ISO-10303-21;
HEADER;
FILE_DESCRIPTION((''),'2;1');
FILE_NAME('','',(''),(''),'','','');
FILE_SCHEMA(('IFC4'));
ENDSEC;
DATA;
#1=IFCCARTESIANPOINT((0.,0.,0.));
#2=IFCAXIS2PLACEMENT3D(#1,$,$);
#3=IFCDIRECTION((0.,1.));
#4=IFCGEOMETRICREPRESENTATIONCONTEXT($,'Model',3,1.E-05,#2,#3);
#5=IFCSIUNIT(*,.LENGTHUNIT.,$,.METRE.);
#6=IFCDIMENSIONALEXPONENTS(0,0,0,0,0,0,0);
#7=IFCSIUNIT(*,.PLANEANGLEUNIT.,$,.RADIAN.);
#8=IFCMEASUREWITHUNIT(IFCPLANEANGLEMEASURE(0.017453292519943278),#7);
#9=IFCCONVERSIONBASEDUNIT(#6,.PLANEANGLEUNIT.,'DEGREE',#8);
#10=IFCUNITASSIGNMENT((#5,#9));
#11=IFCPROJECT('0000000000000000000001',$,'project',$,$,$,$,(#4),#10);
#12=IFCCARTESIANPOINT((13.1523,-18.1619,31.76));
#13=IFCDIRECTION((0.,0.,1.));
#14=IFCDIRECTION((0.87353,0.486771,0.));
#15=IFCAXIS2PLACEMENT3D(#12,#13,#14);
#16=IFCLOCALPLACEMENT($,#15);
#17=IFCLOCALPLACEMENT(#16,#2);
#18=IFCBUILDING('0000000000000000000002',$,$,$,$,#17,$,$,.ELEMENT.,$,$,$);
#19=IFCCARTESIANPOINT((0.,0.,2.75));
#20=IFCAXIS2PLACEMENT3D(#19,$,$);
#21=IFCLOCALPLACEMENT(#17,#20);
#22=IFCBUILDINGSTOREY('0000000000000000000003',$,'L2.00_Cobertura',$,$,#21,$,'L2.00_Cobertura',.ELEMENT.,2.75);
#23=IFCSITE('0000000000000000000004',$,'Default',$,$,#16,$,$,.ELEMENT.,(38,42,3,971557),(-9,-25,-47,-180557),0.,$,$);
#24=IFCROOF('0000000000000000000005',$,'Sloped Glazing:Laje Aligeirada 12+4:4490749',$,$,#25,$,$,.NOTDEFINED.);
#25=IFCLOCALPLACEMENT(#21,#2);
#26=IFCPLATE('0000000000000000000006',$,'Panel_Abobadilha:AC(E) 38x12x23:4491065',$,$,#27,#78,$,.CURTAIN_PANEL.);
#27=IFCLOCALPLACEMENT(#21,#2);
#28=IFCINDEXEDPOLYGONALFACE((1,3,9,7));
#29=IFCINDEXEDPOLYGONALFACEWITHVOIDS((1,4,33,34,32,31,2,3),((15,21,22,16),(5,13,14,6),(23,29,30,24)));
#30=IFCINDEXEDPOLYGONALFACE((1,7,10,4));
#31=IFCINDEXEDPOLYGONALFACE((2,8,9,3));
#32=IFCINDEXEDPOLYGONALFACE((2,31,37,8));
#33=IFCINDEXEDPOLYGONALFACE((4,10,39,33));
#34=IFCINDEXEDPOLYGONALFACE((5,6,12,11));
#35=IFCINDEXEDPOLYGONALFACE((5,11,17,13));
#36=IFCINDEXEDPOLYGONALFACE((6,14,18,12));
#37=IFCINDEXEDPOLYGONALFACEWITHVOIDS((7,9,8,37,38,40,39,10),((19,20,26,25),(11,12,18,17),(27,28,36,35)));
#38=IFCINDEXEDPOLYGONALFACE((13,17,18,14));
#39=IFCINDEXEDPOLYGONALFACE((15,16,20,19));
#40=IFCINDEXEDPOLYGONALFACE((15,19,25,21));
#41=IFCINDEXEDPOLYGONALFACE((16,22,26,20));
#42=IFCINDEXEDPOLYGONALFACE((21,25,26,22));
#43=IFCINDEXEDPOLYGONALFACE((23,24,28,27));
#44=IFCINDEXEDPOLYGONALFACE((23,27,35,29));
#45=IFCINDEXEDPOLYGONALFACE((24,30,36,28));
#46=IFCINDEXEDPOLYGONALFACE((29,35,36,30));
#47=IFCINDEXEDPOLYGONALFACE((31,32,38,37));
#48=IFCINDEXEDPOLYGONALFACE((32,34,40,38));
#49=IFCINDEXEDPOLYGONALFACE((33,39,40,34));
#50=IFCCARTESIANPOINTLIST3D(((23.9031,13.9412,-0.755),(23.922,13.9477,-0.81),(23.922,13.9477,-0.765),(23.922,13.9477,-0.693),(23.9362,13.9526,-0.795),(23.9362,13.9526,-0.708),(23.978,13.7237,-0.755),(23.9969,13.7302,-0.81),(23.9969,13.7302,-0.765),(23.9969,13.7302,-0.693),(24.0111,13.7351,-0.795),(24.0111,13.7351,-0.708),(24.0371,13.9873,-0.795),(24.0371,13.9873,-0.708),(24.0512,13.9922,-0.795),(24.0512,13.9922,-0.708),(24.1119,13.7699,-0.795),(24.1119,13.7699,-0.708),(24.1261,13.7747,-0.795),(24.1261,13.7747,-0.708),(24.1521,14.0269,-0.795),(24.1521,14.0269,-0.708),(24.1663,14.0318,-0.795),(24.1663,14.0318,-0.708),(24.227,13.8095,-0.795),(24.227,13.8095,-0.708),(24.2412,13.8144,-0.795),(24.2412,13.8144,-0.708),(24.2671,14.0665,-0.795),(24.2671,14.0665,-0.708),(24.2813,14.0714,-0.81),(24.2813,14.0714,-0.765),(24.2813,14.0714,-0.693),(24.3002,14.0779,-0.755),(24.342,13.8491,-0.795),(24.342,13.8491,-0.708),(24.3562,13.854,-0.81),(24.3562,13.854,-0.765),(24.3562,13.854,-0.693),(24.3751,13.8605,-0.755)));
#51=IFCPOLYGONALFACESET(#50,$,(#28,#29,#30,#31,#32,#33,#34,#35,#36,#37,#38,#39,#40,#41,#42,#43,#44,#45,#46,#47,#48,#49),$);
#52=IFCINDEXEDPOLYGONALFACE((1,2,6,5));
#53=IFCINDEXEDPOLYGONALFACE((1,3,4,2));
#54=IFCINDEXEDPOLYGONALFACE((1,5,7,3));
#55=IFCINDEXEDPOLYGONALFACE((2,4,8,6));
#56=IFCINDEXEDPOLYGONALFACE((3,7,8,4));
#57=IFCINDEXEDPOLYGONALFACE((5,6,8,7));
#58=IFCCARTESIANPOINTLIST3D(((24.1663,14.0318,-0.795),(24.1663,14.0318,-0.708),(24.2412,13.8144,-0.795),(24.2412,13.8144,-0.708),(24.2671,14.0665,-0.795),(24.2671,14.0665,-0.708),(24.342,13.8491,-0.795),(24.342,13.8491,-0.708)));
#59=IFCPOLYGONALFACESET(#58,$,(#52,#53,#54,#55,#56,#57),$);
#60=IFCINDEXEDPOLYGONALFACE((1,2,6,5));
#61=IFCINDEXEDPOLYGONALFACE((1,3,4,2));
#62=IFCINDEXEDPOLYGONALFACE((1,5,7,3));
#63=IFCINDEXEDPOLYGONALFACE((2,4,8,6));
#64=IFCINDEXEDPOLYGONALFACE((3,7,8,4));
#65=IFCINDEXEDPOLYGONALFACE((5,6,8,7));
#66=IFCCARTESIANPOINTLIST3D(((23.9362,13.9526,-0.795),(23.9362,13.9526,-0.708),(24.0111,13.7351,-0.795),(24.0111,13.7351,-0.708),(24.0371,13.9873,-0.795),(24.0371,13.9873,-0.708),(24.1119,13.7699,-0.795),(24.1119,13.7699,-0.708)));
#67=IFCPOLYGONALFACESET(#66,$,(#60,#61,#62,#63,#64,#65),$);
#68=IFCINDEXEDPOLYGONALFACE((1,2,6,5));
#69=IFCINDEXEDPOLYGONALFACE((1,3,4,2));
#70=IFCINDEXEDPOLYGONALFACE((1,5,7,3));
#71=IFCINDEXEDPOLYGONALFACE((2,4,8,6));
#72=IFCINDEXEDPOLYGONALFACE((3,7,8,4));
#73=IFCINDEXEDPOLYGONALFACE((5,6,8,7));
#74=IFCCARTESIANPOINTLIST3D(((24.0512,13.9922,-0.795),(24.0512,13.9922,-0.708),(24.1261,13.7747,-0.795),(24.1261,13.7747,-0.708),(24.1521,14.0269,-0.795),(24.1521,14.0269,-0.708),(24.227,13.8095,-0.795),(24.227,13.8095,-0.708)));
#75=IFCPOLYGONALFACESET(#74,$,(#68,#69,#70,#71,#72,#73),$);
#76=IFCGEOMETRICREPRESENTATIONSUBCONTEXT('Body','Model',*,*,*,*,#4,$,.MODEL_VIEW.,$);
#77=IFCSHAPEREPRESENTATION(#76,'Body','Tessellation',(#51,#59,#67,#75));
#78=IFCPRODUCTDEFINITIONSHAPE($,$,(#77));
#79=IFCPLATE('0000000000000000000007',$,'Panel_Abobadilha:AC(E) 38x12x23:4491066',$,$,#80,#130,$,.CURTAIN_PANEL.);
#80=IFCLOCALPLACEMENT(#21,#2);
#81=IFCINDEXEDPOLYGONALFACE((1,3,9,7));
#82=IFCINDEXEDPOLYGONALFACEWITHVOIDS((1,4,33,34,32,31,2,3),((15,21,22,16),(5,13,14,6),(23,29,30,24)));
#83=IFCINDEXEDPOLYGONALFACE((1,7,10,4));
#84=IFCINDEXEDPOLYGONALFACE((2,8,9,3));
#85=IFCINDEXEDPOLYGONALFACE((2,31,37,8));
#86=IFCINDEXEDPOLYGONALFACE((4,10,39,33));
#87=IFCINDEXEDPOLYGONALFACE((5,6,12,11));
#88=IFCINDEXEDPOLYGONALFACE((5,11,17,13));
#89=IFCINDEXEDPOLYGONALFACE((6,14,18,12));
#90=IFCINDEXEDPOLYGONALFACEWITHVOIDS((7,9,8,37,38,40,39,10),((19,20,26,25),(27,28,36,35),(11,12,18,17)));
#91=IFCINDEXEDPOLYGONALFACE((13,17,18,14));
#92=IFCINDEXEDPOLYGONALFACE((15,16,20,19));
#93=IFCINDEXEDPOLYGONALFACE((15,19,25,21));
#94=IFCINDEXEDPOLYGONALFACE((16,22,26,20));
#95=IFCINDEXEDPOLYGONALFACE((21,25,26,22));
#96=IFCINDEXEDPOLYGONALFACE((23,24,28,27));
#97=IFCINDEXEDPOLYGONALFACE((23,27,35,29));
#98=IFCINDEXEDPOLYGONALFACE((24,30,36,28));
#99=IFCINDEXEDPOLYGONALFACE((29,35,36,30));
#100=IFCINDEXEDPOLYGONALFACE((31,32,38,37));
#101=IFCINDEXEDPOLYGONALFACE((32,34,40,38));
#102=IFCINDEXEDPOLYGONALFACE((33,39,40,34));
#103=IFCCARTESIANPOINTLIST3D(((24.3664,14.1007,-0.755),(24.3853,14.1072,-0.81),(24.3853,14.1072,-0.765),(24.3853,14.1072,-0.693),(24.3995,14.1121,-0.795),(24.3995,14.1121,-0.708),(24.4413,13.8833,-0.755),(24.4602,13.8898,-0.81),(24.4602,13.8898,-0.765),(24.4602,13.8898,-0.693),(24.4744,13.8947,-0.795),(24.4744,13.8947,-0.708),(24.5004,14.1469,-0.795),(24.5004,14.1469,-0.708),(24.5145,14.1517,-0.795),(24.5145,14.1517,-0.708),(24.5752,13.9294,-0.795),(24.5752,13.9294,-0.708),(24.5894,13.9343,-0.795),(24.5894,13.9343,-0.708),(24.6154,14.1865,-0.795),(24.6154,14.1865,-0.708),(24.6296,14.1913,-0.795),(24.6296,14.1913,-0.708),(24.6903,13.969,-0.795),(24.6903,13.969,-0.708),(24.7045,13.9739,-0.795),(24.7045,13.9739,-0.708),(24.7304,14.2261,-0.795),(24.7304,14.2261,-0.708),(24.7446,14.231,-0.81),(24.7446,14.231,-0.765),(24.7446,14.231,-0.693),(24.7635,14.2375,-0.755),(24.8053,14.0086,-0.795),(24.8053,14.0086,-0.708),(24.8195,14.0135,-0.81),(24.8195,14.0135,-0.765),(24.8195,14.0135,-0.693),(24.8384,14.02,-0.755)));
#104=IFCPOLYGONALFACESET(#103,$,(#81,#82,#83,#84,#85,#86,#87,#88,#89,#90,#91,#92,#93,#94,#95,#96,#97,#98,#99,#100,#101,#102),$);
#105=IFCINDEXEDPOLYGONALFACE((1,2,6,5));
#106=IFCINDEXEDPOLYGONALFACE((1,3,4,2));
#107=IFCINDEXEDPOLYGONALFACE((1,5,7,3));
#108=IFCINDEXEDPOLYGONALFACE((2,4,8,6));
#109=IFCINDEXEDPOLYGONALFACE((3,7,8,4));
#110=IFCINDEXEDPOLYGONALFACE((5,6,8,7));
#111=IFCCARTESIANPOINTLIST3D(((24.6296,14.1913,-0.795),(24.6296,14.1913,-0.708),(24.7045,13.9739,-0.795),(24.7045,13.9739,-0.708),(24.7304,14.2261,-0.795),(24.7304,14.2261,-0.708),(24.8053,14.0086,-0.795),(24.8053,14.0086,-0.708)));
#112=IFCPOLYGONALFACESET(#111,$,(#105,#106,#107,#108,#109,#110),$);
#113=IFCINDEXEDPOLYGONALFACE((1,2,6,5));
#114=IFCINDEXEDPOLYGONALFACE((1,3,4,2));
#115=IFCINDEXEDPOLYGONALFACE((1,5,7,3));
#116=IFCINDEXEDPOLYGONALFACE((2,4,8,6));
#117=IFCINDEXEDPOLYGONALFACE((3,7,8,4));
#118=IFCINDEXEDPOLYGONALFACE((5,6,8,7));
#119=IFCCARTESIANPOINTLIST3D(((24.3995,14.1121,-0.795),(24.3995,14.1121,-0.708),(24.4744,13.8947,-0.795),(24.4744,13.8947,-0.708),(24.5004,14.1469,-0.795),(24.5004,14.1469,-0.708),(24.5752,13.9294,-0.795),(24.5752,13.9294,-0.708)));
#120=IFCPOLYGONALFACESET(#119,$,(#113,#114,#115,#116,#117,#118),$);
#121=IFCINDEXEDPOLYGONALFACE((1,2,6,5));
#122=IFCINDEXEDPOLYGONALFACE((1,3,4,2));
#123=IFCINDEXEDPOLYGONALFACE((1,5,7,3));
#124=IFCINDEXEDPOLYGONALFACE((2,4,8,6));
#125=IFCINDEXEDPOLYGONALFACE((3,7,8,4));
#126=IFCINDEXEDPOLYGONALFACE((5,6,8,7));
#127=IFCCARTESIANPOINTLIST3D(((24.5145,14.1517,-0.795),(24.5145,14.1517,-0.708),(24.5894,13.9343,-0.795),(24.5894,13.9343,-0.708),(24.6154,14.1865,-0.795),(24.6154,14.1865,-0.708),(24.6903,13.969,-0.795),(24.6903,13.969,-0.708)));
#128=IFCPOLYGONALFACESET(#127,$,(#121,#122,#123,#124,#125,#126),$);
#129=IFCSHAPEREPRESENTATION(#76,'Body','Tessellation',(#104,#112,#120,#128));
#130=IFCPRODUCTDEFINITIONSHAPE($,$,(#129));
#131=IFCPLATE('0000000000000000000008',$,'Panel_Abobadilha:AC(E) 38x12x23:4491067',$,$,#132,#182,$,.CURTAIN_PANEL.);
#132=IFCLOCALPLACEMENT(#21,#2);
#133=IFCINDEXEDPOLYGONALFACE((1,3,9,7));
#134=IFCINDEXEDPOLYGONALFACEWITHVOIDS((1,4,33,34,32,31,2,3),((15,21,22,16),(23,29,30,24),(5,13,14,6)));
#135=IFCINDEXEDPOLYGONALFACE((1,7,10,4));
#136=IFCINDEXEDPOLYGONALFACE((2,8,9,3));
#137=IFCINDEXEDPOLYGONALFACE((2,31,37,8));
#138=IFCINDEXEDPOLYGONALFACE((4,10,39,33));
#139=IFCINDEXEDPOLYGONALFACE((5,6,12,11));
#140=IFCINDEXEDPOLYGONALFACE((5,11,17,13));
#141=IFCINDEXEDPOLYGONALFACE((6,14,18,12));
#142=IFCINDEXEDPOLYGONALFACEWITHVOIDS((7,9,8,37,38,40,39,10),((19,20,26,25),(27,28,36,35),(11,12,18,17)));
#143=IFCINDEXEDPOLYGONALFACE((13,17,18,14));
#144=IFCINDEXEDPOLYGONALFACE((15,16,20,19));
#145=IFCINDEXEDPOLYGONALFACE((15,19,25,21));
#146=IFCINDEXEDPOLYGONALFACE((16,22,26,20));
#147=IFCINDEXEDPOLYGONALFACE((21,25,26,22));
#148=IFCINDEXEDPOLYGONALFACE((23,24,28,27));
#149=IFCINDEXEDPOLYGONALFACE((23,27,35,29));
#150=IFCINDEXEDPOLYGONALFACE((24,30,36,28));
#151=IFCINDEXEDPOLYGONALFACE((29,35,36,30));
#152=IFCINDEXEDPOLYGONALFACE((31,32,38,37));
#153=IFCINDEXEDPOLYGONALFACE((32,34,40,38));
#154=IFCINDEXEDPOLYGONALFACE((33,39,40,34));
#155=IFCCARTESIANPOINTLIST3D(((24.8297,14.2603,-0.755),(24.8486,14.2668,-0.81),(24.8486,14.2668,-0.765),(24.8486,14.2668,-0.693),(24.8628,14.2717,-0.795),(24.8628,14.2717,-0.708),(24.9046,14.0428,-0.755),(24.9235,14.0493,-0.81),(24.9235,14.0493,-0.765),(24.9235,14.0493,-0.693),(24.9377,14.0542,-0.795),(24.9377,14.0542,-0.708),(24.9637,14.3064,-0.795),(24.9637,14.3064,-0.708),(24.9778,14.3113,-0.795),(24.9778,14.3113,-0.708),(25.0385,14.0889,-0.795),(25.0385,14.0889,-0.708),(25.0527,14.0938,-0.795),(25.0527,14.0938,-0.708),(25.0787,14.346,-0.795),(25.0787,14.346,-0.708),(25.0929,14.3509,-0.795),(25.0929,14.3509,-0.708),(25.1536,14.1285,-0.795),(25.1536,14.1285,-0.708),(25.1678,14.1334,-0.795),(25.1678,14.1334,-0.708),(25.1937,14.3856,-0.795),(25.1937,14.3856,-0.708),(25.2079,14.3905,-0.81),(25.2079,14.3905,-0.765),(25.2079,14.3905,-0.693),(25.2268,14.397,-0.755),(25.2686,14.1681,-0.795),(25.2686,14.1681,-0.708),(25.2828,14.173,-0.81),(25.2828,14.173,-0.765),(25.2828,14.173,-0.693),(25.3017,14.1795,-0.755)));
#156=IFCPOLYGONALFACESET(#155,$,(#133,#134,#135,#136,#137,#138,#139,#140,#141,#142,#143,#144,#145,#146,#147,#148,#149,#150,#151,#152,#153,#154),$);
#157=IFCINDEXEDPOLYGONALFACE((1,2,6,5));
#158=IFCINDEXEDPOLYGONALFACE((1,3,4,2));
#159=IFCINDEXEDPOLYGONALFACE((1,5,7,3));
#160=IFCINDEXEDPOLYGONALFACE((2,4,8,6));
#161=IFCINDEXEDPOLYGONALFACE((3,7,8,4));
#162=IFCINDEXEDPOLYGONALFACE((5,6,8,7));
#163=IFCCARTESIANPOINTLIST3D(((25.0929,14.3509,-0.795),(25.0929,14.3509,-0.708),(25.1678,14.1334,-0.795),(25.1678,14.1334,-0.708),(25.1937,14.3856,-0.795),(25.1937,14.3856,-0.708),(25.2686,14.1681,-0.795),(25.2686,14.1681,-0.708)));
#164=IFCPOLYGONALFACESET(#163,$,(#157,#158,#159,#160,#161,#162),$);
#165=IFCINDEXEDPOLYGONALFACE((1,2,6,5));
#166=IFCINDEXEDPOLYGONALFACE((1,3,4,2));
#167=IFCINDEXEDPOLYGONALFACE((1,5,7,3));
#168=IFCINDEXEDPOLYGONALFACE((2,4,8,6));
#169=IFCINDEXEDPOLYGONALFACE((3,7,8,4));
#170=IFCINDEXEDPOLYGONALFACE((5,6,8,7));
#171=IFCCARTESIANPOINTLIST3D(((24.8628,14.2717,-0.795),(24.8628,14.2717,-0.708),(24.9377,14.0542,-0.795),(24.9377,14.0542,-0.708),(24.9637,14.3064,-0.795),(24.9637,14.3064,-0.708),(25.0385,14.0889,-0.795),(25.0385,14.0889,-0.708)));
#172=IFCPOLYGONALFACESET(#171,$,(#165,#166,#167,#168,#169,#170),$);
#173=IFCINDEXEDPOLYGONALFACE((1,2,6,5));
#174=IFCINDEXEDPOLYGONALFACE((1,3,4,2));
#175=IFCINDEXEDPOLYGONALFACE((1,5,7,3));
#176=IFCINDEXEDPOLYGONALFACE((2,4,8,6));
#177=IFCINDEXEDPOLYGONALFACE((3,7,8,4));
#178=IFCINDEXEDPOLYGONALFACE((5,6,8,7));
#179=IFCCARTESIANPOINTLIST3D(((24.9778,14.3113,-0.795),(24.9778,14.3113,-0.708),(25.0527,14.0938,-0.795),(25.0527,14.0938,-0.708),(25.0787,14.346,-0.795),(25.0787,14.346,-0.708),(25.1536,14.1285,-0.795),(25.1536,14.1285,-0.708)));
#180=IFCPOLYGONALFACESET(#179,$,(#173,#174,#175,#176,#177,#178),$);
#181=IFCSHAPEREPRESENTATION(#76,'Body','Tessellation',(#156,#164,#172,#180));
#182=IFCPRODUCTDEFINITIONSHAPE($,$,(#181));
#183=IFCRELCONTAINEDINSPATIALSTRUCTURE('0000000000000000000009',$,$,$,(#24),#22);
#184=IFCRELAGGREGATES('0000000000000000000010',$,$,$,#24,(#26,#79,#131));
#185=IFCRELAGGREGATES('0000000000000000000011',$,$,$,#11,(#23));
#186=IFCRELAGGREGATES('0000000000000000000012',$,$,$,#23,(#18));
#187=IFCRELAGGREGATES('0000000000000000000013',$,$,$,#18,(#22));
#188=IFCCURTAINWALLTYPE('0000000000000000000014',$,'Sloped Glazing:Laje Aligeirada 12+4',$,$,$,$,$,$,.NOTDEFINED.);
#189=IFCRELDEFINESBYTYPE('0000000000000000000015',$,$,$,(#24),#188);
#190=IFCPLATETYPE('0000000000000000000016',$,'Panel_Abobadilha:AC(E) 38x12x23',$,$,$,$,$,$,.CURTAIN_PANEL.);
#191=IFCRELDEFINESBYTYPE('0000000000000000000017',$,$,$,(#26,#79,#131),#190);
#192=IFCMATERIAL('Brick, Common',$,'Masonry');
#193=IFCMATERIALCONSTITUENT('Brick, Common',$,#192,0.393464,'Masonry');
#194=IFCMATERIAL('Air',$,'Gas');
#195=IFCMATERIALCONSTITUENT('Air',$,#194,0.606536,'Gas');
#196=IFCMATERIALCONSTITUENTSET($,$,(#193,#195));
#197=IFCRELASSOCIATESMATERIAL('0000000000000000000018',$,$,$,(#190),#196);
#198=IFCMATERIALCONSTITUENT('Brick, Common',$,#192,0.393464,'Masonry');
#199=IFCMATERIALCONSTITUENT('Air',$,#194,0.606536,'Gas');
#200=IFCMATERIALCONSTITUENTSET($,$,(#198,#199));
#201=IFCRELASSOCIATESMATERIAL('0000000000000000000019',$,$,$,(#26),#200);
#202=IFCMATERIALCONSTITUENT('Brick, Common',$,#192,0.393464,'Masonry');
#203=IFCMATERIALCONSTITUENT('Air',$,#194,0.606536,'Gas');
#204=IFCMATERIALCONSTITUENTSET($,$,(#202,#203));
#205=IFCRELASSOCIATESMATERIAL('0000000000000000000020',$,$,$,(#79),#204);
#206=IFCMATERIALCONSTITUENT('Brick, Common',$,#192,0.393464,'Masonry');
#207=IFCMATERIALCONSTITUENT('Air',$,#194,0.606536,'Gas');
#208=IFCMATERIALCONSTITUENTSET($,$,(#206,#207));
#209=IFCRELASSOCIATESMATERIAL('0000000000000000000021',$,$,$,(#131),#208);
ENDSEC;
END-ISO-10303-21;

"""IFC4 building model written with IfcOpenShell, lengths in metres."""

from ifc_helpers import new_model, entity, si_unit, converted_unit, direction, frame, origin, place, context, subcontext, project, spatial, indexed_curve, outline, extrude, source, transform, mapped, material, constituent, constituent_set, type_object, type_shapes, element, aggregate, save


model = new_model("IFC4")

# Units and contexts
model_context = context("Model", 3, precision=1e-05, world=origin(), true_north=direction((0.0, 1.0)))
body_context = subcontext(model_context, "Body", "Model", "MODEL_VIEW")
ifc_project = project(units=[si_unit("LENGTHUNIT", "METRE"), converted_unit("PLANEANGLEUNIT", "DEGREE", entity("IfcPlaneAngleMeasure", 0.017453292519943278), si_unit("PLANEANGLEUNIT", "RADIAN"), dimensions=[0, 0, 0, 0, 0, 0, 0])], contexts=[model_context])

# Site, building, storey
site_placement = place(None, frame((13.1523, -18.1619, 31.76), z_axis=(0.0, 0.0, 1.0), x_axis=(0.87353, 0.486771, 0.0)))
site = spatial("IfcSite", under=ifc_project, at=site_placement, Name="Default", CompositionType="ELEMENT", RefLatitude=(38, 42, 3, 971557), RefLongitude=(-9, -25, -47, -180557), RefElevation=0.0)
building_placement = place(site_placement, origin())
building = spatial("IfcBuilding", under=site, at=building_placement, CompositionType="ELEMENT")
storey_placement = place(building_placement, frame((0.0, 0.0, 2.75)))
storey = spatial("IfcBuildingStorey", under=building, at=storey_placement, Name="L2.00_Cobertura", LongName="L2.00_Cobertura", CompositionType="ELEMENT", Elevation=2.75)

# Roof, plates
curtain_wall_type = type_object("IfcCurtainWallType", Name="Sloped Glazing:Laje Aligeirada 12+4", PredefinedType="NOTDEFINED")
roof_placement = place(storey_placement, frame((0.0, 0.0, -2.75)))
roof = element("IfcRoof", 1, at=roof_placement, inside=storey, type_object=curtain_wall_type, Name="Sloped Glazing:Laje Aligeirada 12+4:4490749", PredefinedType="NOTDEFINED")
ifc_material_1 = material(Name="Brick, Common", Category="Masonry")
ifc_material_2 = material(Name="Air", Category="Gas")
ifc_constituent_1 = constituent(ifc_material_1, Name="Brick, Common", Category="Masonry", fraction=0.393464)
ifc_constituent_2 = constituent(ifc_material_2, Name="Air", Category="Gas", fraction=0.606536)
ifc_constituent_set_1 = constituent_set(constituents=[ifc_constituent_1, ifc_constituent_2])
plate_type = type_object("IfcPlateType", Name="Panel_Abobadilha:AC(E) 38x12x23", PredefinedType="CURTAIN_PANEL", material=ifc_constituent_set_1)
shared_shape_1 = source(origin(), body_context, "Body", "SweptSolid", [
    extrude(outline(indexed_curve([(-0.19, -0.0543), (0.19, -0.0543), (0.19, -0.0093), (0.21, 0.0007), (0.19, 0.0628), (-0.19, 0.0628), (-0.21, 0.0007), (-0.19, -0.0093), (-0.19, -0.0543)], self_intersect=False), holes=[indexed_curve([(-0.0683, 0.0477), (-0.0683, -0.0393), (-0.175, -0.0393), (-0.175, 0.0477), (-0.0683, 0.0477)], self_intersect=False), indexed_curve([(0.0533, 0.0477), (0.0533, -0.0393), (-0.0533, -0.0393), (-0.0533, 0.0477), (0.0533, 0.0477)], self_intersect=False), indexed_curve([(0.175, 0.0477), (0.175, -0.0393), (0.0683, -0.0393), (0.0683, 0.0477), (0.175, 0.0477)], self_intersect=False)]), frame((0.0, 0.0543, 0.0)), (0.0, 0.0, 1.0), 0.23),
    extrude(outline(indexed_curve([(-0.0533, -0.0435), (0.0533, -0.0435), (0.0533, 0.0435), (-0.0533, 0.0435), (-0.0533, -0.0435)], self_intersect=False)), frame((0.1217, 0.0585, 0.0), z_axis=(0.0, 0.0, 1.0), x_axis=(-1.0, 0.0, 0.0)), (0.0, 0.0, 1.0), 0.23),
    extrude(outline(indexed_curve([(-0.0533, -0.0435), (0.0533, -0.0435), (0.0533, 0.0435), (-0.0533, 0.0435), (-0.0533, -0.0435)], self_intersect=False)), frame((-0.1217, 0.0585, 0.0), z_axis=(0.0, 0.0, 1.0), x_axis=(-1.0, 0.0, 0.0)), (0.0, 0.0, 1.0), 0.23),
    extrude(outline(indexed_curve([(-0.0533, -0.0435), (0.0533, -0.0435), (0.0533, 0.0435), (-0.0533, 0.0435), (-0.0533, -0.0435)], self_intersect=False)), frame((0.0, 0.0585, 0.0), z_axis=(0.0, 0.0, 1.0), x_axis=(-1.0, 0.0, 0.0)), (0.0, 0.0, 1.0), 0.23),
])
type_shapes(plate_type, [shared_shape_1])
ifc_constituent_3 = constituent(ifc_material_1, Name="Brick, Common", Category="Masonry", fraction=0.393464)
ifc_constituent_4 = constituent(ifc_material_2, Name="Air", Category="Gas", fraction=0.606536)
ifc_constituent_set_2 = constituent_set(constituents=[ifc_constituent_3, ifc_constituent_4])
plate_1_placement = place(roof_placement, frame((24.1017, 14.0096, 1.94), z_axis=(0.325568, -0.945519, 0.0), x_axis=(0.945519, 0.325568, 0.0)))
plate_1 = element("IfcPlate", 2, at=plate_1_placement, type_object=plate_type, material=ifc_constituent_set_2, Name="Panel_Abobadilha:AC(E) 38x12x23:4491065", PredefinedType="CURTAIN_PANEL", context=body_context, shape_type="MappedRepresentation", body=[
    mapped(shared_shape_1, transform((0.0, 0.0, 0.0), scale=1.0)),
])
ifc_constituent_5 = constituent(ifc_material_1, Name="Brick, Common", Category="Masonry", fraction=0.393464)
ifc_constituent_6 = constituent(ifc_material_2, Name="Air", Category="Gas", fraction=0.606536)
ifc_constituent_set_3 = constituent_set(constituents=[ifc_constituent_5, ifc_constituent_6])
plate_2_placement = place(roof_placement, frame((24.565, 14.1691, 1.94), z_axis=(0.325568, -0.945519, 0.0), x_axis=(0.945519, 0.325568, 0.0)))
plate_2 = element("IfcPlate", 3, at=plate_2_placement, type_object=plate_type, material=ifc_constituent_set_3, Name="Panel_Abobadilha:AC(E) 38x12x23:4491066", PredefinedType="CURTAIN_PANEL", context=body_context, shape_type="MappedRepresentation", body=[
    mapped(shared_shape_1, transform((0.0, 0.0, 0.0), scale=1.0)),
])
ifc_constituent_7 = constituent(ifc_material_1, Name="Brick, Common", Category="Masonry", fraction=0.393464)
ifc_constituent_8 = constituent(ifc_material_2, Name="Air", Category="Gas", fraction=0.606536)
ifc_constituent_set_4 = constituent_set(constituents=[ifc_constituent_7, ifc_constituent_8])
plate_3_placement = place(roof_placement, frame((25.0283, 14.3286, 1.94), z_axis=(0.325568, -0.945519, 0.0), x_axis=(0.945519, 0.325568, 0.0)))
plate_3 = element("IfcPlate", 4, at=plate_3_placement, type_object=plate_type, material=ifc_constituent_set_4, Name="Panel_Abobadilha:AC(E) 38x12x23:4491067", PredefinedType="CURTAIN_PANEL", context=body_context, shape_type="MappedRepresentation", body=[
    mapped(shared_shape_1, transform((0.0, 0.0, 0.0), scale=1.0)),
])
aggregate(roof, [plate_1, plate_2, plate_3])

save(model, "model.ifc")
